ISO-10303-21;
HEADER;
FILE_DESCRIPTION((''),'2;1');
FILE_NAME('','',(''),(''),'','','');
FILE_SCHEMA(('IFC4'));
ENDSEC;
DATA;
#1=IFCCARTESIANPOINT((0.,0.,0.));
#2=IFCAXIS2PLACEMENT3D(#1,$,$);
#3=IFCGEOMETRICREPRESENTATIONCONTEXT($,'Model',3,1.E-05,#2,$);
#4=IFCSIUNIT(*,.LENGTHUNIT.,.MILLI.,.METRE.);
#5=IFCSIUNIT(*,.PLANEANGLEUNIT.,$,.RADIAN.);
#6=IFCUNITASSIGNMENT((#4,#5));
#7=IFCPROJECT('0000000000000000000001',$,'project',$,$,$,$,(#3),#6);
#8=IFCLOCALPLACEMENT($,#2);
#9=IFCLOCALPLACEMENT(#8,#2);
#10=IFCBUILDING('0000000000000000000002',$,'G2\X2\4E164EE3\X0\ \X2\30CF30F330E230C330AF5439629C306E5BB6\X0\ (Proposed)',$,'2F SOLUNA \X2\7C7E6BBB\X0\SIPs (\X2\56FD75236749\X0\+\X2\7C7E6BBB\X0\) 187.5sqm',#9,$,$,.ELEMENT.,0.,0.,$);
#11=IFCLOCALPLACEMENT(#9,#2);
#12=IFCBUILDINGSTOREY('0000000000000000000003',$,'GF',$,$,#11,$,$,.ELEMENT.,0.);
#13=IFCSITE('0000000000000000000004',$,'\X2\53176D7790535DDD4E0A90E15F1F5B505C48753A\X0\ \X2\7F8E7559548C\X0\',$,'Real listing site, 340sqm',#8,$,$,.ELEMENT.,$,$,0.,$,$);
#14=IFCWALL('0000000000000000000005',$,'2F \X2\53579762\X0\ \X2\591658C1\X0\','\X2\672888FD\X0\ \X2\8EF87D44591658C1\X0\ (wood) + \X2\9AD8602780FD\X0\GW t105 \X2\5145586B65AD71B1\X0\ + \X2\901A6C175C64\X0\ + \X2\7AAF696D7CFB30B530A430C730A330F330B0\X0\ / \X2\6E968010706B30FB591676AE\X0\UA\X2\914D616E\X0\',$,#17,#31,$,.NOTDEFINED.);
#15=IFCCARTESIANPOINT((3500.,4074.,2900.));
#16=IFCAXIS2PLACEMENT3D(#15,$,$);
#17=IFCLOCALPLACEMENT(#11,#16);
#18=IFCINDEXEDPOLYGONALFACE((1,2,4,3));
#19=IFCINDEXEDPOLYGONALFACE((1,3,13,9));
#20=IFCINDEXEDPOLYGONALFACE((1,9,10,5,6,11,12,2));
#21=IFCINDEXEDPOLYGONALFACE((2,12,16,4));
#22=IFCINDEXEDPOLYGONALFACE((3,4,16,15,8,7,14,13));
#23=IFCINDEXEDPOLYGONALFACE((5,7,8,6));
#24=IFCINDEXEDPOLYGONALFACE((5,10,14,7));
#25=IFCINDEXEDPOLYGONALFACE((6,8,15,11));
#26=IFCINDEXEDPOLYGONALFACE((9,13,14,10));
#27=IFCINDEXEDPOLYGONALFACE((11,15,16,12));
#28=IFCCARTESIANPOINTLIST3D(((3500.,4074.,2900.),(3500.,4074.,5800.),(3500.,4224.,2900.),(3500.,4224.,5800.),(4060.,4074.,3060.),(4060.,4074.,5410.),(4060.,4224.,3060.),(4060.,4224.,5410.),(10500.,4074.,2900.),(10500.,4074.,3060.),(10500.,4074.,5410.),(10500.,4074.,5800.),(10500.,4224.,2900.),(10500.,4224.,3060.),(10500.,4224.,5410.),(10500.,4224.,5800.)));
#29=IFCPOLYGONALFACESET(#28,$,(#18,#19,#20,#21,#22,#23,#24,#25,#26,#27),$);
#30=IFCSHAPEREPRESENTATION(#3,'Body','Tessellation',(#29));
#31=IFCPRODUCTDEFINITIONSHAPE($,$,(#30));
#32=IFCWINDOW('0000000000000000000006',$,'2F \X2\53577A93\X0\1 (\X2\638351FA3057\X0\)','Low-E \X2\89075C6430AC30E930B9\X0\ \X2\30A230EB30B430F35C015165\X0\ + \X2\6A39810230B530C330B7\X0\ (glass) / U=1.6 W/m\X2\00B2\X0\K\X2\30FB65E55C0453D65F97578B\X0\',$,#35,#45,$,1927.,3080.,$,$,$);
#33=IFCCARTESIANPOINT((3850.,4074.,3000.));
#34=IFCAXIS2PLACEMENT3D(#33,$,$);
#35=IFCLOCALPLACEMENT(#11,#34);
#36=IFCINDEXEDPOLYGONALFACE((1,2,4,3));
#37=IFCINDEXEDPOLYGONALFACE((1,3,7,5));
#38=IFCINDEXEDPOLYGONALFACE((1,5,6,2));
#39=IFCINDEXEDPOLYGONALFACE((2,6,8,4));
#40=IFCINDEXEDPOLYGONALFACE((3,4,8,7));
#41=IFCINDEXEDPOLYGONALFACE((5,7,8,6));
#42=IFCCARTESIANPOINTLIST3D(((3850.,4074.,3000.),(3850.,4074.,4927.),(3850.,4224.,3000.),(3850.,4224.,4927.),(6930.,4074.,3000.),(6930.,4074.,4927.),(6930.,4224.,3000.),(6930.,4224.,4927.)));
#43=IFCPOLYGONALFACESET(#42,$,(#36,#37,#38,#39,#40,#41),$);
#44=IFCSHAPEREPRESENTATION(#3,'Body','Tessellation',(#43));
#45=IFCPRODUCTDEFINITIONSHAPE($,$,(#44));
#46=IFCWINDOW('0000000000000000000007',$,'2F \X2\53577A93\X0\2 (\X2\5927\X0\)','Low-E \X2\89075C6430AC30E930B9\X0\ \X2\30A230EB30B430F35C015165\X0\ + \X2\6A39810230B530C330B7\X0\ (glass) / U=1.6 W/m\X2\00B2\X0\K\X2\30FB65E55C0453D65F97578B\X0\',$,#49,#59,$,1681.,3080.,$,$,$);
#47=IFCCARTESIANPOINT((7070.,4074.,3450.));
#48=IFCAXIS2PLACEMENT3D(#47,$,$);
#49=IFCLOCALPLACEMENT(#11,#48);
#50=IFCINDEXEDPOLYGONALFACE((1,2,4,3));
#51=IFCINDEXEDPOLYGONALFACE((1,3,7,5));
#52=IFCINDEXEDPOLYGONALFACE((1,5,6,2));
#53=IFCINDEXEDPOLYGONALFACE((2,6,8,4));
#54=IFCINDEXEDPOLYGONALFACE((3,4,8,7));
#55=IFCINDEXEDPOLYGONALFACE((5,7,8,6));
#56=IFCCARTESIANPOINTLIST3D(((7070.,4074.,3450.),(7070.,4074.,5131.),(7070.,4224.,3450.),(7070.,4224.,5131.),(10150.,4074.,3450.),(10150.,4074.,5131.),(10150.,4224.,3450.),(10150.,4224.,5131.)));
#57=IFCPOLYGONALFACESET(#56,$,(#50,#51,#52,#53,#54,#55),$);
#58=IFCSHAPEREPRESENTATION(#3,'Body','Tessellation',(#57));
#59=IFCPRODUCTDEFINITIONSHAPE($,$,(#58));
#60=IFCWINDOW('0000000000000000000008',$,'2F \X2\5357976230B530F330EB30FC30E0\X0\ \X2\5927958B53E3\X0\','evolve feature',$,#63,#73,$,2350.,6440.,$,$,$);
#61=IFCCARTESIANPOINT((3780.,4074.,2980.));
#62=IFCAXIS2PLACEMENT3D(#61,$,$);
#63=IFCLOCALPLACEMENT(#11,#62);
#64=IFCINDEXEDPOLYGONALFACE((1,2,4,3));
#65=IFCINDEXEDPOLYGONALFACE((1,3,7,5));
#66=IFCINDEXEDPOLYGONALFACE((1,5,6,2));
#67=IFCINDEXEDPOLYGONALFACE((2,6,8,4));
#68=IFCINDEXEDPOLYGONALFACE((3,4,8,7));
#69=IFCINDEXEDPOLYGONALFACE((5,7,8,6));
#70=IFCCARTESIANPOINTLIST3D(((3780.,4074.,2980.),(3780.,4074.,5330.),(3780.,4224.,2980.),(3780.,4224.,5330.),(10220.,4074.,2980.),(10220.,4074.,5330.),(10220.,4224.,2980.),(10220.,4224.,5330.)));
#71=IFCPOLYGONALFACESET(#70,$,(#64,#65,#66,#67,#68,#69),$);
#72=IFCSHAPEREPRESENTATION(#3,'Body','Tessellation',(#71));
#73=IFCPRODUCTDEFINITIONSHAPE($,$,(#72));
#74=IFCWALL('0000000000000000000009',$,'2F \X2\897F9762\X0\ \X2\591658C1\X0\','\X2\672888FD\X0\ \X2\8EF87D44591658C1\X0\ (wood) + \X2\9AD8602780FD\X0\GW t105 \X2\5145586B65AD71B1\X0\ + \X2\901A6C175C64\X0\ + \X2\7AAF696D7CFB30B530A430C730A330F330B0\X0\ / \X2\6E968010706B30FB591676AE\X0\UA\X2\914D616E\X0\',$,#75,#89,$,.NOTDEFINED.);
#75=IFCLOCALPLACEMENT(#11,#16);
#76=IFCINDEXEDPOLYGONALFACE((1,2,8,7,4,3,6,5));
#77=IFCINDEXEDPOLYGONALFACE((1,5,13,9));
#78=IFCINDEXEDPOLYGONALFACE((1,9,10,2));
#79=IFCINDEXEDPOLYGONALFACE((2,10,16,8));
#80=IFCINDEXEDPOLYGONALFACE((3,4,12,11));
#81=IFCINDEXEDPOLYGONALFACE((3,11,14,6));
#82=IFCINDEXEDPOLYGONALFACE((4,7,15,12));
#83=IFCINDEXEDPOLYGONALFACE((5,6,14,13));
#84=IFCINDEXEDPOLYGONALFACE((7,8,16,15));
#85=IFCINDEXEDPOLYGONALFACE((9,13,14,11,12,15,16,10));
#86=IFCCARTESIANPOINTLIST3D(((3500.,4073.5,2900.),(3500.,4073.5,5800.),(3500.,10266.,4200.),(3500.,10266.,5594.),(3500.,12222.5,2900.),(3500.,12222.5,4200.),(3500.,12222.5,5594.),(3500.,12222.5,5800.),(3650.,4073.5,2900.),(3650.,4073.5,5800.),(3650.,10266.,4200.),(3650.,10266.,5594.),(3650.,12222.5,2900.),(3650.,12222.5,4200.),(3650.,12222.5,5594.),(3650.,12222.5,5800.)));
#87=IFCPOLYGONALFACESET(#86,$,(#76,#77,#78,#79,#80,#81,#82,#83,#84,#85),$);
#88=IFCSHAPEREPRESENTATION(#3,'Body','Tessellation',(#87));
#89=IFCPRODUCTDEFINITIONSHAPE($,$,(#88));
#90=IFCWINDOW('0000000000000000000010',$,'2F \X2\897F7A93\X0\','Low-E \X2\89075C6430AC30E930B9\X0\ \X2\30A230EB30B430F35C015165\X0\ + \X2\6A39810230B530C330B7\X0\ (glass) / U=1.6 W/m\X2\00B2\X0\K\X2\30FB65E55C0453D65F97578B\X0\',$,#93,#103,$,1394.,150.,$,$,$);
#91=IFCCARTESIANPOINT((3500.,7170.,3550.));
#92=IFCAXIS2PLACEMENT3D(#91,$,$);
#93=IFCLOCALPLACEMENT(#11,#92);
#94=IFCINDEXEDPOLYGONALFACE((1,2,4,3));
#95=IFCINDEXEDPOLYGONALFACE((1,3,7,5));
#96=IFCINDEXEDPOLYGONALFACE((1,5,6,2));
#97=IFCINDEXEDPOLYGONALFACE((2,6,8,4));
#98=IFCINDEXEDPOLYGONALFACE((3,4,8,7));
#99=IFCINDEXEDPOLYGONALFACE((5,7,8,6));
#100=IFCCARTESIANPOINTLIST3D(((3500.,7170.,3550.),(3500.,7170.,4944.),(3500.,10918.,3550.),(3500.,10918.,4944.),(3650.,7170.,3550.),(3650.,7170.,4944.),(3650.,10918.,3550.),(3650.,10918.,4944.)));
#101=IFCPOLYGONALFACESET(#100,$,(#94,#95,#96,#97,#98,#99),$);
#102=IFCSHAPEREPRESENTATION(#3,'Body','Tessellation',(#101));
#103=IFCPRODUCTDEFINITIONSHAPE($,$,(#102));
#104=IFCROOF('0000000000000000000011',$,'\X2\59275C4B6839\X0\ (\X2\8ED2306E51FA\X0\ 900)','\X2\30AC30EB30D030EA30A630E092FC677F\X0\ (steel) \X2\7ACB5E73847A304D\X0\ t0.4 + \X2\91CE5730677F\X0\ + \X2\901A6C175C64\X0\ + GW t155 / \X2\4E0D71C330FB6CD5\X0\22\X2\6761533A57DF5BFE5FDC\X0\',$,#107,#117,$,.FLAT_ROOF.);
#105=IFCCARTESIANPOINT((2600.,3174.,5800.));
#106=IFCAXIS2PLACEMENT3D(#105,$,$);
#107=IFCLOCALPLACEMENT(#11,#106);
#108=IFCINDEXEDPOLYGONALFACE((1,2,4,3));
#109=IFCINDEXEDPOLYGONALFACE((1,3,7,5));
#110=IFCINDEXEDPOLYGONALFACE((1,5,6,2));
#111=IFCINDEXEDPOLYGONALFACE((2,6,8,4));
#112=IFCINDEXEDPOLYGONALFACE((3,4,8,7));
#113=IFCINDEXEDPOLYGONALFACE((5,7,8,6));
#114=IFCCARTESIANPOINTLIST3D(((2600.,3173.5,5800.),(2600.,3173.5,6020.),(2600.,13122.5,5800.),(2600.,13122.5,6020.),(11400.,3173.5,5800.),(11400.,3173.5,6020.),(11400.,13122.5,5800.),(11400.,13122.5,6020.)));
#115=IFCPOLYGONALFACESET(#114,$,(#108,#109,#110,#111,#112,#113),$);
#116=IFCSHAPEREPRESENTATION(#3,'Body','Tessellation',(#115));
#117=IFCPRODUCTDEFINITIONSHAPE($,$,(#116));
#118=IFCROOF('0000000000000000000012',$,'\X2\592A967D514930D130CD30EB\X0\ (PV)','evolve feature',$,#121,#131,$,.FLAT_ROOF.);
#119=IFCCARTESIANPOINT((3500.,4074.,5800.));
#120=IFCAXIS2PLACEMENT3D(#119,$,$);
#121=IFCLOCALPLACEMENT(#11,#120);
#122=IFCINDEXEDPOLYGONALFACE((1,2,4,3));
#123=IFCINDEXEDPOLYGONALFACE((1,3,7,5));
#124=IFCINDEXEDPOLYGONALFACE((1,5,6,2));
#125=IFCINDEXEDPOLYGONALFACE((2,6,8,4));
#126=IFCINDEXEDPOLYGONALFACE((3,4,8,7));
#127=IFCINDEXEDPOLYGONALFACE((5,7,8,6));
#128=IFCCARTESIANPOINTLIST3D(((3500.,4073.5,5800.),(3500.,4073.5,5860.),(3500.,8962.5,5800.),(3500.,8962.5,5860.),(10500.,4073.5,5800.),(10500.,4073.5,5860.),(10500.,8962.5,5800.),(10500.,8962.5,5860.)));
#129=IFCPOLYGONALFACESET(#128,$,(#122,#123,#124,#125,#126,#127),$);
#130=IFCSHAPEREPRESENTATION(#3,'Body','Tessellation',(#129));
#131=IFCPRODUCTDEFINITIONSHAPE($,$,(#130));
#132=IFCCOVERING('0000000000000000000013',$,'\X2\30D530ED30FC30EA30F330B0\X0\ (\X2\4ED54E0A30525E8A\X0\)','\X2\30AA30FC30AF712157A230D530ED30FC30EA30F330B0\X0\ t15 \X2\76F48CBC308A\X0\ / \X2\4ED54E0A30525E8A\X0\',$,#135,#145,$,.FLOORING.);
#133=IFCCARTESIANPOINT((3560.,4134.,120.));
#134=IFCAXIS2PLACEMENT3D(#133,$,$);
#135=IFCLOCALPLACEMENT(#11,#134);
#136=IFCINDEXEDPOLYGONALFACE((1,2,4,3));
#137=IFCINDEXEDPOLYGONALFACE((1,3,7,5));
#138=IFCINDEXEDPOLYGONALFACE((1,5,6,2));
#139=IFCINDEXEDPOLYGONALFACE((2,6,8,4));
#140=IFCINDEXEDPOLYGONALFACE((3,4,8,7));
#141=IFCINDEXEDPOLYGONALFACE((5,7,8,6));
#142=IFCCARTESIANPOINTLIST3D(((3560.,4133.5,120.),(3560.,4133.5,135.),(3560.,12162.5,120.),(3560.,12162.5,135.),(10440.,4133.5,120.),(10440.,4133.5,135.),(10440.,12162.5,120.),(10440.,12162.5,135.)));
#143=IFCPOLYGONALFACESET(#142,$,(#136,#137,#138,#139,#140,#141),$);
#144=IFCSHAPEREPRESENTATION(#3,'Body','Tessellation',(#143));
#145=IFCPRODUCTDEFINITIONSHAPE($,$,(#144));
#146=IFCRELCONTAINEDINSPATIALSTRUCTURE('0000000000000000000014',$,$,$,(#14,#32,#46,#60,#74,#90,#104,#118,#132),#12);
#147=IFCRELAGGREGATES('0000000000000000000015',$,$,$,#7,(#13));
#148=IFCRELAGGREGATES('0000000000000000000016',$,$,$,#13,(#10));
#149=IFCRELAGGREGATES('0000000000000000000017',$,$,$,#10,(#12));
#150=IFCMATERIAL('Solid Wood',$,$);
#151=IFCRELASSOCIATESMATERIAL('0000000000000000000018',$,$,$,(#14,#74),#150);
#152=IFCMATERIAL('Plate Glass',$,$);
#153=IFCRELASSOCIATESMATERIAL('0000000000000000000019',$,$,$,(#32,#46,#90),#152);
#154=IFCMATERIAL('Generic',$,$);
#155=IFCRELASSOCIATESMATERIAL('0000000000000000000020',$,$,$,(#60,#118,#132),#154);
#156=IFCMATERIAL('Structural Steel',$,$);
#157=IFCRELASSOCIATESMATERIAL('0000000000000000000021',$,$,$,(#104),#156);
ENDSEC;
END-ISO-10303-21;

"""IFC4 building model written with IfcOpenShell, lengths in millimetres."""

from ifc_helpers import new_model, si_unit, frame, frame_2d, origin, place, context, project, spatial, rectangle, extrude, material, element, fill, save


model = new_model("IFC4")

# Units and contexts
model_context = context("Model", 3, precision=1e-05, world=origin())
ifc_project = project(units=[si_unit("LENGTHUNIT", "METRE", prefix="MILLI"), si_unit("PLANEANGLEUNIT", "RADIAN")], contexts=[model_context])

# Site, building, storey
site_placement = place(None, origin())
site = spatial("IfcSite", under=ifc_project, at=site_placement, Name="北海道川上郡弟子屈町 美留和", ObjectType="Real listing site, 340sqm", CompositionType="ELEMENT", RefElevation=0.0)
building_placement = place(site_placement, origin())
building = spatial("IfcBuilding", under=site, at=building_placement, Name="G2世代 ハンモック吹抜の家 (Proposed)", ObjectType="2F SOLUNA 籾殻SIPs (国産杉+籾殻) 187.5sqm", CompositionType="ELEMENT", ElevationOfRefHeight=0.0, ElevationOfTerrain=0.0)
storey_placement = place(building_placement, origin())
storey = spatial("IfcBuildingStorey", under=building, at=storey_placement, Name="GF", CompositionType="ELEMENT", Elevation=0.0)

# Shared definitions
ifc_material_1 = material(Name="Solid Wood")
ifc_material_2 = material(Name="Generic")

# Shared definitions
ifc_material_3 = material(Name="Plate Glass")

# Wall, openings, windows
wall_1_placement = place(storey_placement, frame((3500.0, 4074.0, 2900.0)))
wall_1 = element("IfcWall", 1, at=wall_1_placement, inside=storey, material=ifc_material_1, Name="2F 南面 外壁", Description="木製 軸組外壁 (wood) + 高性能GW t105 充填断熱 + 通気層 + 窯業系サイディング / 準耐火・外皮UA配慮", PredefinedType="NOTDEFINED", context=model_context, shape_type="SweptSolid", body=[
    extrude(rectangle(XDim=7000.0, YDim=150.0, at=frame_2d((3500.0, 75.0))), frame((3500.0, 4074.0, 2900.0)), (0.0, 0.0, 1.0), 2900.0),
])
opening_1_placement = place(storey_placement, frame((3850.0, 4074.0, 3000.0)))
opening_1 = element("IfcOpeningElement", 2, at=opening_1_placement, cuts=wall_1, PredefinedType="NOTDEFINED", context=model_context, shape_type="SweptSolid", body=[
    extrude(rectangle(XDim=3080.0, YDim=150.0, at=frame_2d((1540.0, 75.0))), frame((3850.0, 4074.0, 3000.0)), (0.0, 0.0, 1.0), 1927.0),
])
opening_2_placement = place(storey_placement, frame((7070.0, 4074.0, 3450.0)))
opening_2 = element("IfcOpeningElement", 3, at=opening_2_placement, cuts=wall_1, PredefinedType="NOTDEFINED", context=model_context, shape_type="SweptSolid", body=[
    extrude(rectangle(XDim=3080.0, YDim=150.0, at=frame_2d((1540.0, 75.0))), frame((7070.0, 4074.0, 3450.0)), (0.0, 0.0, 1.0), 1681.0),
])
opening_3_placement = place(storey_placement, frame((3780.0, 4074.0, 2980.0)))
opening_3 = element("IfcOpeningElement", 4, at=opening_3_placement, cuts=wall_1, PredefinedType="NOTDEFINED", context=model_context, shape_type="SweptSolid", body=[
    extrude(rectangle(XDim=6440.0, YDim=150.0, at=frame_2d((3220.0, 75.0))), frame((3780.0, 4074.0, 2980.0)), (0.0, 0.0, 1.0), 2350.0),
])
window_1_placement = place(storey_placement, frame((3850.0, 4074.0, 3000.0)))
window_1 = element("IfcWindow", 5, at=window_1_placement, inside=storey, material=ifc_material_3, Name="2F 南窓1 (掃出し)", Description="Low-E 複層ガラス アルゴン封入 + 樹脂サッシ (glass) / U=1.6 W/m²K・日射取得型", OverallHeight=1927.0, OverallWidth=3080.0, context=model_context, shape_type="SweptSolid", body=[
    extrude(rectangle(XDim=3080.0, YDim=150.0, at=frame_2d((1540.0, 75.0))), frame((3850.0, 4074.0, 3000.0)), (0.0, 0.0, 1.0), 1927.0),
])
fill(opening_1, window_1)
window_2_placement = place(storey_placement, frame((7070.0, 4074.0, 3450.0)))
window_2 = element("IfcWindow", 6, at=window_2_placement, inside=storey, material=ifc_material_3, Name="2F 南窓2 (大)", Description="Low-E 複層ガラス アルゴン封入 + 樹脂サッシ (glass) / U=1.6 W/m²K・日射取得型", OverallHeight=1681.0, OverallWidth=3080.0, context=model_context, shape_type="SweptSolid", body=[
    extrude(rectangle(XDim=3080.0, YDim=150.0, at=frame_2d((1540.0, 75.0))), frame((7070.0, 4074.0, 3450.0)), (0.0, 0.0, 1.0), 1681.0),
])
fill(opening_2, window_2)
window_3_placement = place(storey_placement, frame((3780.0, 4074.0, 2980.0)))
window_3 = element("IfcWindow", 7, at=window_3_placement, inside=storey, material=ifc_material_2, Name="2F 南面サンルーム 大開口", Description="evolve feature", OverallHeight=2350.0, OverallWidth=6440.0, context=model_context, shape_type="SweptSolid", body=[
    extrude(rectangle(XDim=6440.0, YDim=150.0, at=frame_2d((3220.0, 75.0))), frame((3780.0, 4074.0, 2980.0)), (0.0, 0.0, 1.0), 2350.0),
])
fill(opening_3, window_3)

# Wall, opening, window
wall_2_placement = place(storey_placement, frame((3500.0, 4074.0, 2900.0)))
wall_2 = element("IfcWall", 8, at=wall_2_placement, inside=storey, material=ifc_material_1, Name="2F 西面 外壁", Description="木製 軸組外壁 (wood) + 高性能GW t105 充填断熱 + 通気層 + 窯業系サイディング / 準耐火・外皮UA配慮", PredefinedType="NOTDEFINED", context=model_context, shape_type="SweptSolid", body=[
    extrude(rectangle(XDim=150.0, YDim=8149.0, at=frame_2d((75.0, 4074.0))), frame((3500.0, 4074.0, 2900.0)), (0.0, 0.0, 1.0), 2900.0),
])
opening_4_placement = place(storey_placement, frame((3500.0, 7170.0, 3550.0)))
opening_4 = element("IfcOpeningElement", 9, at=opening_4_placement, cuts=wall_2, PredefinedType="NOTDEFINED", context=model_context, shape_type="SweptSolid", body=[
    extrude(rectangle(XDim=150.0, YDim=3748.0, at=frame_2d((75.0, 1874.0))), frame((3500.0, 7170.0, 3550.0)), (0.0, 0.0, 1.0), 1394.0),
])
window_4_placement = place(storey_placement, frame((3500.0, 7170.0, 3550.0)))
window_4 = element("IfcWindow", 10, at=window_4_placement, inside=storey, material=ifc_material_3, Name="2F 西窓", Description="Low-E 複層ガラス アルゴン封入 + 樹脂サッシ (glass) / U=1.6 W/m²K・日射取得型", OverallHeight=1394.0, OverallWidth=150.0, context=model_context, shape_type="SweptSolid", body=[
    extrude(rectangle(XDim=150.0, YDim=3748.0, at=frame_2d((75.0, 1874.0))), frame((3500.0, 7170.0, 3550.0)), (0.0, 0.0, 1.0), 1394.0),
])
fill(opening_4, window_4)

# Roofs
ifc_material_4 = material(Name="Structural Steel")
roof_1_placement = place(storey_placement, frame((2600.0, 3174.0, 5800.0)))
element("IfcRoof", 11, at=roof_1_placement, inside=storey, material=ifc_material_4, Name="大屋根 (軒の出 900)", Description="ガルバリウム鋼板 (steel) 立平葺き t0.4 + 野地板 + 通気層 + GW t155 / 不燃・法22条区域対応", PredefinedType="FLAT_ROOF", context=model_context, shape_type="SweptSolid", body=[
    extrude(rectangle(XDim=8800.0, YDim=9949.0, at=frame_2d((4400.0, 4974.0))), frame((2600.0, 3174.0, 5800.0)), (0.0, 0.0, 1.0), 220.0),
])
roof_2_placement = place(storey_placement, frame((3500.0, 4074.0, 5800.0)))
element("IfcRoof", 12, at=roof_2_placement, inside=storey, material=ifc_material_2, Name="太陽光パネル (PV)", Description="evolve feature", PredefinedType="FLAT_ROOF", context=model_context, shape_type="SweptSolid", body=[
    extrude(rectangle(XDim=7000.0, YDim=4889.0, at=frame_2d((3500.0, 2444.0))), frame((3500.0, 4074.0, 5800.0)), (0.0, 0.0, 1.0), 60.0),
])

# Covering
covering_placement = place(storey_placement, frame((3560.0, 4134.0, 120.0)))
element("IfcCovering", 13, at=covering_placement, inside=storey, material=ifc_material_2, Name="フローリング (仕上げ床)", Description="オーク無垢フローリング t15 直貼り / 仕上げ床", PredefinedType="FLOORING", context=model_context, shape_type="SweptSolid", body=[
    extrude(rectangle(XDim=6880.0, YDim=8029.0, at=frame_2d((3440.0, 4014.0))), frame((3560.0, 4134.0, 120.0)), (0.0, 0.0, 1.0), 15.0),
])

save(model, "model.ifc")
